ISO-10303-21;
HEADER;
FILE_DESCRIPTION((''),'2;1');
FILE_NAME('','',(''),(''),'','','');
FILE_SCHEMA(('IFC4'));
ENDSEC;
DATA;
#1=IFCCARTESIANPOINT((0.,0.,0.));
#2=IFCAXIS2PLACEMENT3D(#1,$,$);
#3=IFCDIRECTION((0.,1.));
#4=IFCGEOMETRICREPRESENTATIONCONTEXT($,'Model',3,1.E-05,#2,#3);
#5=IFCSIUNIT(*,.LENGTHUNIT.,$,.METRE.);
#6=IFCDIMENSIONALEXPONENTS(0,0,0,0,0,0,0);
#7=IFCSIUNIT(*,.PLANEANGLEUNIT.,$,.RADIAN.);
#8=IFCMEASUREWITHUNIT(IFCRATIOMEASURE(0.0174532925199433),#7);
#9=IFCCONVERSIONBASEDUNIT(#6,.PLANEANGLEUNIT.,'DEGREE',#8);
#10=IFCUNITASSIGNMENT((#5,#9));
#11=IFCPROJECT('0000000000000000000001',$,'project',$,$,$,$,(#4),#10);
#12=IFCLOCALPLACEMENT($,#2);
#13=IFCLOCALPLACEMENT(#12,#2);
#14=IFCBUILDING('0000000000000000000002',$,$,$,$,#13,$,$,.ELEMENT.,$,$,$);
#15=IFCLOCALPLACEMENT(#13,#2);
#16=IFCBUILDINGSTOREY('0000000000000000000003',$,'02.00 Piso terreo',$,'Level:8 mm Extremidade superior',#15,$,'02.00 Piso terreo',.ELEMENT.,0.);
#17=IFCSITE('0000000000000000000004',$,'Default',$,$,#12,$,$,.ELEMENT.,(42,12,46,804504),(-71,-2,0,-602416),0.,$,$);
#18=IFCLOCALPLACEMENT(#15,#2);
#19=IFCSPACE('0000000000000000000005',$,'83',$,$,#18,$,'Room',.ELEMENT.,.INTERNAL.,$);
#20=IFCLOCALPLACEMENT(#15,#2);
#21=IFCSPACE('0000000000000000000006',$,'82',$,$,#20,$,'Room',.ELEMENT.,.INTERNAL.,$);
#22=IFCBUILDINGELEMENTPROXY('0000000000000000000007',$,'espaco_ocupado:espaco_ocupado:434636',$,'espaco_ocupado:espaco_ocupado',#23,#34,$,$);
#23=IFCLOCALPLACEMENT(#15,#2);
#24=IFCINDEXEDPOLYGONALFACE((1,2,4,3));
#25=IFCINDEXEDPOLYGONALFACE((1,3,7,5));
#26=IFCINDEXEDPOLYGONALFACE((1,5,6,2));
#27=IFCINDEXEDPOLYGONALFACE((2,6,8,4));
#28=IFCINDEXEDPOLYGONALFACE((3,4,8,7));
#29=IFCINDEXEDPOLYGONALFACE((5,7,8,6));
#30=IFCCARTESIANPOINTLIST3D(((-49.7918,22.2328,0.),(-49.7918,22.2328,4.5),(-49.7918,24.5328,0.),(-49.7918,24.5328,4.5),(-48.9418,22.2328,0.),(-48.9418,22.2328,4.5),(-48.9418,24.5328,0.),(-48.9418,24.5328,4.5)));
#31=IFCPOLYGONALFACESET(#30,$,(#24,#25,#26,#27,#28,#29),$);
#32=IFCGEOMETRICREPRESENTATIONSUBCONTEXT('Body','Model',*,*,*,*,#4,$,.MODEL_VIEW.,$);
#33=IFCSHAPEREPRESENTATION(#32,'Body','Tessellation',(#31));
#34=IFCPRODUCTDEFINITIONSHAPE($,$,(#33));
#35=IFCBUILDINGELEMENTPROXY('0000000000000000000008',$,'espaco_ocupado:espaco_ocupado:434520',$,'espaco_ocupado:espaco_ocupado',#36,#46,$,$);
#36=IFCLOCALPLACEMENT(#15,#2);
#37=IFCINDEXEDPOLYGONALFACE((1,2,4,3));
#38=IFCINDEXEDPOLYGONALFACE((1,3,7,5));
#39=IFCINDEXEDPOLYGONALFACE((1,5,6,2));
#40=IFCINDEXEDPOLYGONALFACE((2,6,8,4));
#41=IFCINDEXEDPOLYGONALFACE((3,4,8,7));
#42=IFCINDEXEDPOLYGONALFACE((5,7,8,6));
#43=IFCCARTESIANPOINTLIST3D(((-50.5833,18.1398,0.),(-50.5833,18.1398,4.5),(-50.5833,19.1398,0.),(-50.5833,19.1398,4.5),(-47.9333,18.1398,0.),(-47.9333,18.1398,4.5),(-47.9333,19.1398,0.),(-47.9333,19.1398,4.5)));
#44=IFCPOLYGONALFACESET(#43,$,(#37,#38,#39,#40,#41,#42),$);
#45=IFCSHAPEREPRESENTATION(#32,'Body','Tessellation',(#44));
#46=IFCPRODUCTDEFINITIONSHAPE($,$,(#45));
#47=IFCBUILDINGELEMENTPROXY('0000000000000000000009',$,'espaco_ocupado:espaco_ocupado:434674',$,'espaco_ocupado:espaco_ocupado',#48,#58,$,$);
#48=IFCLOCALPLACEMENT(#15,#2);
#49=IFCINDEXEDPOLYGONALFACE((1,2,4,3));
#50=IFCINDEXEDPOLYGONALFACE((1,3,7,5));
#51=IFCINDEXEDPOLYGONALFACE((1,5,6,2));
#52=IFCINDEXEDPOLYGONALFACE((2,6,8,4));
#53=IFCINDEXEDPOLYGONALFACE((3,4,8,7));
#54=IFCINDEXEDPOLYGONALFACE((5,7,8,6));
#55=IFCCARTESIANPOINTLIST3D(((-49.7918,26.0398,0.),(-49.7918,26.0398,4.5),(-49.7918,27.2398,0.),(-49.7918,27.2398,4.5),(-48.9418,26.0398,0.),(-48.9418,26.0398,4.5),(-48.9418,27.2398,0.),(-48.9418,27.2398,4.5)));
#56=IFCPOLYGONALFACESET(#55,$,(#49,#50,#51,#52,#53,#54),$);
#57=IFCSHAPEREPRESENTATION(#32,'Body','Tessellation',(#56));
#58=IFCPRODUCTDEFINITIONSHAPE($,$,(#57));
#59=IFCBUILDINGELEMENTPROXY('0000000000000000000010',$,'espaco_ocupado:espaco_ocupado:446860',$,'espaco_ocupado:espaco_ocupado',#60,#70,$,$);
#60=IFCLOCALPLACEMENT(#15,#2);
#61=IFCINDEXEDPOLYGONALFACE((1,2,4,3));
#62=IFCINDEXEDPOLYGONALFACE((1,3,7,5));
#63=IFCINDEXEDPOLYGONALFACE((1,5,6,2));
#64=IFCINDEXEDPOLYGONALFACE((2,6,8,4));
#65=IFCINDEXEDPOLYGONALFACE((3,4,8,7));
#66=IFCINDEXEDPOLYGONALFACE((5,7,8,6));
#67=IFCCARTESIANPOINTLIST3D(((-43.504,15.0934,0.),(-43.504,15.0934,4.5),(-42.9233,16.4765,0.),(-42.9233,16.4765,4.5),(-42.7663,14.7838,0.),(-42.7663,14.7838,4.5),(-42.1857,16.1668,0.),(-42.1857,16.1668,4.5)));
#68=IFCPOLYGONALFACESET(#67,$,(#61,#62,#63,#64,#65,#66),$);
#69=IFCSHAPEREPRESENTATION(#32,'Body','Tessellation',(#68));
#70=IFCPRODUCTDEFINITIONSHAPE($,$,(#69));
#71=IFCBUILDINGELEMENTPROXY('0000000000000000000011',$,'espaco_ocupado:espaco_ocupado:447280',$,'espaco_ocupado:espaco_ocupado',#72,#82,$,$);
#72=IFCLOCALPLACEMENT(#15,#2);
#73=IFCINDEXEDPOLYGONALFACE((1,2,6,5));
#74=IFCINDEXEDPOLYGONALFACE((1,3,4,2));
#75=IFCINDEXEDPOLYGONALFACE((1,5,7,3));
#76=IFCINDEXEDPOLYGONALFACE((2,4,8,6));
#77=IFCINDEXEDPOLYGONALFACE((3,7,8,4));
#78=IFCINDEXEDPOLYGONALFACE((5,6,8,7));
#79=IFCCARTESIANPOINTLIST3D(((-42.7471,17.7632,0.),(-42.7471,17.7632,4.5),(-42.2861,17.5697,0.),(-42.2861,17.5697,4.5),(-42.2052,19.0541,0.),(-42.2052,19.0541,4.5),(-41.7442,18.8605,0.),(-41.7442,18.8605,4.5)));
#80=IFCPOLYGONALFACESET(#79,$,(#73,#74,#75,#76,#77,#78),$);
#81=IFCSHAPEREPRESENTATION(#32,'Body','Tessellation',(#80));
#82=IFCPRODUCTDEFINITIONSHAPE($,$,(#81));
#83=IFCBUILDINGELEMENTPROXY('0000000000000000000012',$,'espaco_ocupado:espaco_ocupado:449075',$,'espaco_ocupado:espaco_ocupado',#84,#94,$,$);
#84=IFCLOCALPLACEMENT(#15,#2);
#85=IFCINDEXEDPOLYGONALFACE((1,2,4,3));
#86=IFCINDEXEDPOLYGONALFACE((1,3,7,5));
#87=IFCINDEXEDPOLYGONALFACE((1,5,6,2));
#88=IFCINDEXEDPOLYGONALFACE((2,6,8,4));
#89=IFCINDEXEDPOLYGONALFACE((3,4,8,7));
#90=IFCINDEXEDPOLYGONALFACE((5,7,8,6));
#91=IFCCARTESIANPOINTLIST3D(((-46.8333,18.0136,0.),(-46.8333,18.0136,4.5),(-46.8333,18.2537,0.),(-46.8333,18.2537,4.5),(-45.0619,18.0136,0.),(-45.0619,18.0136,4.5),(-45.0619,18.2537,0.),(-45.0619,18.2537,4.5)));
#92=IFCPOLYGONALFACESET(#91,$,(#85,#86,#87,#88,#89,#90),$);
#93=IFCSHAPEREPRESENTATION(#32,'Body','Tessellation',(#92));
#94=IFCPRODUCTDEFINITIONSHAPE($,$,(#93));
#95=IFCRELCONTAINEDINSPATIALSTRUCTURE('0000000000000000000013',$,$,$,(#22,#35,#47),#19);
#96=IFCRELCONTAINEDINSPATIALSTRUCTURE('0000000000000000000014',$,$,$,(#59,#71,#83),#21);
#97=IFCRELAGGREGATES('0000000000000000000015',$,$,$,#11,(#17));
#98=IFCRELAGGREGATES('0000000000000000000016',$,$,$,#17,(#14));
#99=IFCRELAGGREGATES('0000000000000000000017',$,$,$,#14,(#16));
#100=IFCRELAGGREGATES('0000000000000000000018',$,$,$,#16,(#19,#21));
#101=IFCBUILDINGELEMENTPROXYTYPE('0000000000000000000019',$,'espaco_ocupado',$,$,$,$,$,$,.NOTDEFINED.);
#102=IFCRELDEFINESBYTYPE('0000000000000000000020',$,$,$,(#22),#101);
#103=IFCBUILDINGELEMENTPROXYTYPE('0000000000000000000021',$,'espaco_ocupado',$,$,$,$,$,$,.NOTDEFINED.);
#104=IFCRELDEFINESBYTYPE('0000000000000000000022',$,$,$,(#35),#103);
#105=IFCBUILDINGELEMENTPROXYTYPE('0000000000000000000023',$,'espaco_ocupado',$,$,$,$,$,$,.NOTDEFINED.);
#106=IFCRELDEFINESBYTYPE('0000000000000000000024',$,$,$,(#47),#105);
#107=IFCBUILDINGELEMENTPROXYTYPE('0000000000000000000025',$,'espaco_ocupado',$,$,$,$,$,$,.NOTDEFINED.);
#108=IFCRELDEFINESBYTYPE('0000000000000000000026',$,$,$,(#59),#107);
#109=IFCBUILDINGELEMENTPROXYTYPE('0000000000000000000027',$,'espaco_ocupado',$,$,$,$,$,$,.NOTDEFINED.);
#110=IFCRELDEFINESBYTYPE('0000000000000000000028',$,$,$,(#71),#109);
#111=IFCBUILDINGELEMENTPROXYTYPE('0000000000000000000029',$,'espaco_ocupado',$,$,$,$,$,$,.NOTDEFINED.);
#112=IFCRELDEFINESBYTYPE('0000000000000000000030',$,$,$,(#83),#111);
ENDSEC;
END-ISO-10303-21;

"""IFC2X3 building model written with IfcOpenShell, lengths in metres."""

from ifc_helpers import new_model, entity, si_unit, converted_unit, direction, frame, frame_2d, origin, origin_2d_with_axis, place, context, subcontext, project, spatial, rectangle, extrude, source, transform, mapped, type_object, type_shapes, element, save


model = new_model("IFC2X3")

# Units and contexts
model_context = context("Model", 3, precision=1e-05, world=origin(), true_north=direction((0.0, 1.0)))
body_context = subcontext(model_context, "Body", "Model", "MODEL_VIEW")
ifc_project = project(units=[si_unit("LENGTHUNIT", "METRE"), converted_unit("PLANEANGLEUNIT", "DEGREE", entity("IfcRatioMeasure", 0.0174532925199433), si_unit("PLANEANGLEUNIT", "RADIAN"), dimensions=[0, 0, 0, 0, 0, 0, 0])], contexts=[model_context])

# Site, building, storey
site_placement = place(None, origin())
site = spatial("IfcSite", under=ifc_project, at=site_placement, Name="Default", CompositionType="ELEMENT", RefLatitude=(42, 12, 46, 804504), RefLongitude=(-71, -2, 0, -602416), RefElevation=0.0)
building_placement = place(site_placement, origin())
building = spatial("IfcBuilding", under=site, at=building_placement, CompositionType="ELEMENT")
storey_placement = place(building_placement, origin())
storey = spatial("IfcBuildingStorey", under=building, at=storey_placement, Name="02.00 Piso terreo", ObjectType="Level:8 mm Extremidade superior", LongName="02.00 Piso terreo", CompositionType="ELEMENT", Elevation=0.0)

# Shared definitions
space_1_placement = place(storey_placement, origin())
space_1 = spatial("IfcSpace", under=storey, at=space_1_placement, Name="83", LongName="Room", CompositionType="ELEMENT", InteriorOrExteriorSpace="INTERNAL")

# Building element proxies
building_element_proxy_type_1 = type_object("IfcBuildingElementProxyType", Name="espaco_ocupado", PredefinedType="NOTDEFINED")
shared_shape_1 = source(origin(), body_context, "Body", "SweptSolid", [
    extrude(rectangle(XDim=0.85, YDim=2.3, at=origin_2d_with_axis()), frame((0.0, 0.0, 0.0), z_axis=(0.0, 0.0, 1.0), x_axis=(-1.0, 0.0, 0.0)), (0.0, 0.0, 1.0), 4.5),
])
type_shapes(building_element_proxy_type_1, [shared_shape_1])
proxy_1_placement = place(space_1_placement, frame((-49.3668, 23.3828, 0.0)))
element("IfcBuildingElementProxy", 1, at=proxy_1_placement, inside=space_1, type_object=building_element_proxy_type_1, Name="espaco_ocupado:espaco_ocupado:434636", ObjectType="espaco_ocupado:espaco_ocupado", context=body_context, shape_type="MappedRepresentation", body=[
    mapped(shared_shape_1, transform((0.0, 0.0, 0.0), scale=1.0)),
])
building_element_proxy_type_2 = type_object("IfcBuildingElementProxyType", Name="espaco_ocupado", PredefinedType="NOTDEFINED")
shared_shape_2 = source(origin(), body_context, "Body", "SweptSolid", [
    extrude(rectangle(XDim=2.65, YDim=1.0, at=origin_2d_with_axis()), frame((0.0, 0.0, 0.0), z_axis=(0.0, 0.0, 1.0), x_axis=(-1.0, 0.0, 0.0)), (0.0, 0.0, 1.0), 4.5),
])
type_shapes(building_element_proxy_type_2, [shared_shape_2])
proxy_2_placement = place(space_1_placement, frame((-49.2583, 18.6398, 0.0)))
element("IfcBuildingElementProxy", 2, at=proxy_2_placement, inside=space_1, type_object=building_element_proxy_type_2, Name="espaco_ocupado:espaco_ocupado:434520", ObjectType="espaco_ocupado:espaco_ocupado", context=body_context, shape_type="MappedRepresentation", body=[
    mapped(shared_shape_2, transform((0.0, 0.0, 0.0), scale=1.0)),
])
building_element_proxy_type_3 = type_object("IfcBuildingElementProxyType", Name="espaco_ocupado", PredefinedType="NOTDEFINED")
shared_shape_3 = source(origin(), body_context, "Body", "SweptSolid", [
    extrude(rectangle(XDim=0.85, YDim=1.2, at=origin_2d_with_axis()), frame((0.0, 0.0, 0.0), z_axis=(0.0, 0.0, 1.0), x_axis=(-1.0, 0.0, 0.0)), (0.0, 0.0, 1.0), 4.5),
])
type_shapes(building_element_proxy_type_3, [shared_shape_3])
proxy_3_placement = place(space_1_placement, frame((-49.3668, 26.6398, 0.0)))
element("IfcBuildingElementProxy", 3, at=proxy_3_placement, inside=space_1, type_object=building_element_proxy_type_3, Name="espaco_ocupado:espaco_ocupado:434674", ObjectType="espaco_ocupado:espaco_ocupado", context=body_context, shape_type="MappedRepresentation", body=[
    mapped(shared_shape_3, transform((0.0, 0.0, 0.0), scale=1.0)),
])

# Shared definitions
space_2_placement = place(storey_placement, origin())
space_2 = spatial("IfcSpace", under=storey, at=space_2_placement, Name="82", LongName="Room", CompositionType="ELEMENT", InteriorOrExteriorSpace="INTERNAL")

# Building element proxies
building_element_proxy_type_4 = type_object("IfcBuildingElementProxyType", Name="espaco_ocupado", PredefinedType="NOTDEFINED")
shared_shape_4 = source(origin(), body_context, "Body", "SweptSolid", [
    extrude(rectangle(XDim=1.5, YDim=0.8, at=origin_2d_with_axis()), frame((0.0, 0.0, 0.0), z_axis=(0.0, 0.0, 1.0), x_axis=(-1.0, 0.0, 0.0)), (0.0, 0.0, 1.0), 4.5),
])
type_shapes(building_element_proxy_type_4, [shared_shape_4])
proxy_4_placement = place(space_2_placement, frame((-42.8448, 15.6301, 0.0), z_axis=(0.0, 0.0, 1.0), x_axis=(0.387097, 0.922039, 0.0)))
element("IfcBuildingElementProxy", 4, at=proxy_4_placement, inside=space_2, type_object=building_element_proxy_type_4, Name="espaco_ocupado:espaco_ocupado:446860", ObjectType="espaco_ocupado:espaco_ocupado", context=body_context, shape_type="MappedRepresentation", body=[
    mapped(shared_shape_4, transform((0.0, 0.0, 0.0), scale=1.0)),
])
building_element_proxy_type_5 = type_object("IfcBuildingElementProxyType", Name="espaco_ocupado", PredefinedType="NOTDEFINED")
shared_shape_5 = source(origin(), body_context, "Body", "SweptSolid", [
    extrude(rectangle(XDim=1.4, YDim=0.5, at=origin_2d_with_axis()), frame((0.0, 0.0, 0.0), z_axis=(0.0, 0.0, 1.0), x_axis=(-1.0, 0.0, 0.0)), (0.0, 0.0, 1.0), 4.5),
])
type_shapes(building_element_proxy_type_5, [shared_shape_5])
proxy_5_placement = place(space_2_placement, frame((-42.2456, 18.3119, 0.0), z_axis=(0.0, 0.0, 1.0), x_axis=(0.387097, 0.922039, 0.0)))
element("IfcBuildingElementProxy", 5, at=proxy_5_placement, inside=space_2, type_object=building_element_proxy_type_5, Name="espaco_ocupado:espaco_ocupado:447280", ObjectType="espaco_ocupado:espaco_ocupado", context=body_context, shape_type="MappedRepresentation", body=[
    mapped(shared_shape_5, transform((0.0, 0.0, 0.0), scale=1.0)),
])
building_element_proxy_type_6 = type_object("IfcBuildingElementProxyType", Name="espaco_ocupado", PredefinedType="NOTDEFINED")
shared_shape_6 = source(origin(), body_context, "Body", "SweptSolid", [
    extrude(rectangle(XDim=1.7714, YDim=0.24, at=frame_2d((0.0, 0.0), x_axis=(1.0, 0.0))), frame((0.0, 0.0, 0.0), z_axis=(0.0, 0.0, 1.0), x_axis=(-1.0, 0.0, 0.0)), (0.0, 0.0, 1.0), 4.5),
])
type_shapes(building_element_proxy_type_6, [shared_shape_6])
proxy_6_placement = place(space_2_placement, frame((-45.9476, 18.1337, 0.0)))
element("IfcBuildingElementProxy", 6, at=proxy_6_placement, inside=space_2, type_object=building_element_proxy_type_6, Name="espaco_ocupado:espaco_ocupado:449075", ObjectType="espaco_ocupado:espaco_ocupado", context=body_context, shape_type="MappedRepresentation", body=[
    mapped(shared_shape_6, transform((0.0, 0.0, 0.0), scale=1.0)),
])

save(model, "model.ifc")
